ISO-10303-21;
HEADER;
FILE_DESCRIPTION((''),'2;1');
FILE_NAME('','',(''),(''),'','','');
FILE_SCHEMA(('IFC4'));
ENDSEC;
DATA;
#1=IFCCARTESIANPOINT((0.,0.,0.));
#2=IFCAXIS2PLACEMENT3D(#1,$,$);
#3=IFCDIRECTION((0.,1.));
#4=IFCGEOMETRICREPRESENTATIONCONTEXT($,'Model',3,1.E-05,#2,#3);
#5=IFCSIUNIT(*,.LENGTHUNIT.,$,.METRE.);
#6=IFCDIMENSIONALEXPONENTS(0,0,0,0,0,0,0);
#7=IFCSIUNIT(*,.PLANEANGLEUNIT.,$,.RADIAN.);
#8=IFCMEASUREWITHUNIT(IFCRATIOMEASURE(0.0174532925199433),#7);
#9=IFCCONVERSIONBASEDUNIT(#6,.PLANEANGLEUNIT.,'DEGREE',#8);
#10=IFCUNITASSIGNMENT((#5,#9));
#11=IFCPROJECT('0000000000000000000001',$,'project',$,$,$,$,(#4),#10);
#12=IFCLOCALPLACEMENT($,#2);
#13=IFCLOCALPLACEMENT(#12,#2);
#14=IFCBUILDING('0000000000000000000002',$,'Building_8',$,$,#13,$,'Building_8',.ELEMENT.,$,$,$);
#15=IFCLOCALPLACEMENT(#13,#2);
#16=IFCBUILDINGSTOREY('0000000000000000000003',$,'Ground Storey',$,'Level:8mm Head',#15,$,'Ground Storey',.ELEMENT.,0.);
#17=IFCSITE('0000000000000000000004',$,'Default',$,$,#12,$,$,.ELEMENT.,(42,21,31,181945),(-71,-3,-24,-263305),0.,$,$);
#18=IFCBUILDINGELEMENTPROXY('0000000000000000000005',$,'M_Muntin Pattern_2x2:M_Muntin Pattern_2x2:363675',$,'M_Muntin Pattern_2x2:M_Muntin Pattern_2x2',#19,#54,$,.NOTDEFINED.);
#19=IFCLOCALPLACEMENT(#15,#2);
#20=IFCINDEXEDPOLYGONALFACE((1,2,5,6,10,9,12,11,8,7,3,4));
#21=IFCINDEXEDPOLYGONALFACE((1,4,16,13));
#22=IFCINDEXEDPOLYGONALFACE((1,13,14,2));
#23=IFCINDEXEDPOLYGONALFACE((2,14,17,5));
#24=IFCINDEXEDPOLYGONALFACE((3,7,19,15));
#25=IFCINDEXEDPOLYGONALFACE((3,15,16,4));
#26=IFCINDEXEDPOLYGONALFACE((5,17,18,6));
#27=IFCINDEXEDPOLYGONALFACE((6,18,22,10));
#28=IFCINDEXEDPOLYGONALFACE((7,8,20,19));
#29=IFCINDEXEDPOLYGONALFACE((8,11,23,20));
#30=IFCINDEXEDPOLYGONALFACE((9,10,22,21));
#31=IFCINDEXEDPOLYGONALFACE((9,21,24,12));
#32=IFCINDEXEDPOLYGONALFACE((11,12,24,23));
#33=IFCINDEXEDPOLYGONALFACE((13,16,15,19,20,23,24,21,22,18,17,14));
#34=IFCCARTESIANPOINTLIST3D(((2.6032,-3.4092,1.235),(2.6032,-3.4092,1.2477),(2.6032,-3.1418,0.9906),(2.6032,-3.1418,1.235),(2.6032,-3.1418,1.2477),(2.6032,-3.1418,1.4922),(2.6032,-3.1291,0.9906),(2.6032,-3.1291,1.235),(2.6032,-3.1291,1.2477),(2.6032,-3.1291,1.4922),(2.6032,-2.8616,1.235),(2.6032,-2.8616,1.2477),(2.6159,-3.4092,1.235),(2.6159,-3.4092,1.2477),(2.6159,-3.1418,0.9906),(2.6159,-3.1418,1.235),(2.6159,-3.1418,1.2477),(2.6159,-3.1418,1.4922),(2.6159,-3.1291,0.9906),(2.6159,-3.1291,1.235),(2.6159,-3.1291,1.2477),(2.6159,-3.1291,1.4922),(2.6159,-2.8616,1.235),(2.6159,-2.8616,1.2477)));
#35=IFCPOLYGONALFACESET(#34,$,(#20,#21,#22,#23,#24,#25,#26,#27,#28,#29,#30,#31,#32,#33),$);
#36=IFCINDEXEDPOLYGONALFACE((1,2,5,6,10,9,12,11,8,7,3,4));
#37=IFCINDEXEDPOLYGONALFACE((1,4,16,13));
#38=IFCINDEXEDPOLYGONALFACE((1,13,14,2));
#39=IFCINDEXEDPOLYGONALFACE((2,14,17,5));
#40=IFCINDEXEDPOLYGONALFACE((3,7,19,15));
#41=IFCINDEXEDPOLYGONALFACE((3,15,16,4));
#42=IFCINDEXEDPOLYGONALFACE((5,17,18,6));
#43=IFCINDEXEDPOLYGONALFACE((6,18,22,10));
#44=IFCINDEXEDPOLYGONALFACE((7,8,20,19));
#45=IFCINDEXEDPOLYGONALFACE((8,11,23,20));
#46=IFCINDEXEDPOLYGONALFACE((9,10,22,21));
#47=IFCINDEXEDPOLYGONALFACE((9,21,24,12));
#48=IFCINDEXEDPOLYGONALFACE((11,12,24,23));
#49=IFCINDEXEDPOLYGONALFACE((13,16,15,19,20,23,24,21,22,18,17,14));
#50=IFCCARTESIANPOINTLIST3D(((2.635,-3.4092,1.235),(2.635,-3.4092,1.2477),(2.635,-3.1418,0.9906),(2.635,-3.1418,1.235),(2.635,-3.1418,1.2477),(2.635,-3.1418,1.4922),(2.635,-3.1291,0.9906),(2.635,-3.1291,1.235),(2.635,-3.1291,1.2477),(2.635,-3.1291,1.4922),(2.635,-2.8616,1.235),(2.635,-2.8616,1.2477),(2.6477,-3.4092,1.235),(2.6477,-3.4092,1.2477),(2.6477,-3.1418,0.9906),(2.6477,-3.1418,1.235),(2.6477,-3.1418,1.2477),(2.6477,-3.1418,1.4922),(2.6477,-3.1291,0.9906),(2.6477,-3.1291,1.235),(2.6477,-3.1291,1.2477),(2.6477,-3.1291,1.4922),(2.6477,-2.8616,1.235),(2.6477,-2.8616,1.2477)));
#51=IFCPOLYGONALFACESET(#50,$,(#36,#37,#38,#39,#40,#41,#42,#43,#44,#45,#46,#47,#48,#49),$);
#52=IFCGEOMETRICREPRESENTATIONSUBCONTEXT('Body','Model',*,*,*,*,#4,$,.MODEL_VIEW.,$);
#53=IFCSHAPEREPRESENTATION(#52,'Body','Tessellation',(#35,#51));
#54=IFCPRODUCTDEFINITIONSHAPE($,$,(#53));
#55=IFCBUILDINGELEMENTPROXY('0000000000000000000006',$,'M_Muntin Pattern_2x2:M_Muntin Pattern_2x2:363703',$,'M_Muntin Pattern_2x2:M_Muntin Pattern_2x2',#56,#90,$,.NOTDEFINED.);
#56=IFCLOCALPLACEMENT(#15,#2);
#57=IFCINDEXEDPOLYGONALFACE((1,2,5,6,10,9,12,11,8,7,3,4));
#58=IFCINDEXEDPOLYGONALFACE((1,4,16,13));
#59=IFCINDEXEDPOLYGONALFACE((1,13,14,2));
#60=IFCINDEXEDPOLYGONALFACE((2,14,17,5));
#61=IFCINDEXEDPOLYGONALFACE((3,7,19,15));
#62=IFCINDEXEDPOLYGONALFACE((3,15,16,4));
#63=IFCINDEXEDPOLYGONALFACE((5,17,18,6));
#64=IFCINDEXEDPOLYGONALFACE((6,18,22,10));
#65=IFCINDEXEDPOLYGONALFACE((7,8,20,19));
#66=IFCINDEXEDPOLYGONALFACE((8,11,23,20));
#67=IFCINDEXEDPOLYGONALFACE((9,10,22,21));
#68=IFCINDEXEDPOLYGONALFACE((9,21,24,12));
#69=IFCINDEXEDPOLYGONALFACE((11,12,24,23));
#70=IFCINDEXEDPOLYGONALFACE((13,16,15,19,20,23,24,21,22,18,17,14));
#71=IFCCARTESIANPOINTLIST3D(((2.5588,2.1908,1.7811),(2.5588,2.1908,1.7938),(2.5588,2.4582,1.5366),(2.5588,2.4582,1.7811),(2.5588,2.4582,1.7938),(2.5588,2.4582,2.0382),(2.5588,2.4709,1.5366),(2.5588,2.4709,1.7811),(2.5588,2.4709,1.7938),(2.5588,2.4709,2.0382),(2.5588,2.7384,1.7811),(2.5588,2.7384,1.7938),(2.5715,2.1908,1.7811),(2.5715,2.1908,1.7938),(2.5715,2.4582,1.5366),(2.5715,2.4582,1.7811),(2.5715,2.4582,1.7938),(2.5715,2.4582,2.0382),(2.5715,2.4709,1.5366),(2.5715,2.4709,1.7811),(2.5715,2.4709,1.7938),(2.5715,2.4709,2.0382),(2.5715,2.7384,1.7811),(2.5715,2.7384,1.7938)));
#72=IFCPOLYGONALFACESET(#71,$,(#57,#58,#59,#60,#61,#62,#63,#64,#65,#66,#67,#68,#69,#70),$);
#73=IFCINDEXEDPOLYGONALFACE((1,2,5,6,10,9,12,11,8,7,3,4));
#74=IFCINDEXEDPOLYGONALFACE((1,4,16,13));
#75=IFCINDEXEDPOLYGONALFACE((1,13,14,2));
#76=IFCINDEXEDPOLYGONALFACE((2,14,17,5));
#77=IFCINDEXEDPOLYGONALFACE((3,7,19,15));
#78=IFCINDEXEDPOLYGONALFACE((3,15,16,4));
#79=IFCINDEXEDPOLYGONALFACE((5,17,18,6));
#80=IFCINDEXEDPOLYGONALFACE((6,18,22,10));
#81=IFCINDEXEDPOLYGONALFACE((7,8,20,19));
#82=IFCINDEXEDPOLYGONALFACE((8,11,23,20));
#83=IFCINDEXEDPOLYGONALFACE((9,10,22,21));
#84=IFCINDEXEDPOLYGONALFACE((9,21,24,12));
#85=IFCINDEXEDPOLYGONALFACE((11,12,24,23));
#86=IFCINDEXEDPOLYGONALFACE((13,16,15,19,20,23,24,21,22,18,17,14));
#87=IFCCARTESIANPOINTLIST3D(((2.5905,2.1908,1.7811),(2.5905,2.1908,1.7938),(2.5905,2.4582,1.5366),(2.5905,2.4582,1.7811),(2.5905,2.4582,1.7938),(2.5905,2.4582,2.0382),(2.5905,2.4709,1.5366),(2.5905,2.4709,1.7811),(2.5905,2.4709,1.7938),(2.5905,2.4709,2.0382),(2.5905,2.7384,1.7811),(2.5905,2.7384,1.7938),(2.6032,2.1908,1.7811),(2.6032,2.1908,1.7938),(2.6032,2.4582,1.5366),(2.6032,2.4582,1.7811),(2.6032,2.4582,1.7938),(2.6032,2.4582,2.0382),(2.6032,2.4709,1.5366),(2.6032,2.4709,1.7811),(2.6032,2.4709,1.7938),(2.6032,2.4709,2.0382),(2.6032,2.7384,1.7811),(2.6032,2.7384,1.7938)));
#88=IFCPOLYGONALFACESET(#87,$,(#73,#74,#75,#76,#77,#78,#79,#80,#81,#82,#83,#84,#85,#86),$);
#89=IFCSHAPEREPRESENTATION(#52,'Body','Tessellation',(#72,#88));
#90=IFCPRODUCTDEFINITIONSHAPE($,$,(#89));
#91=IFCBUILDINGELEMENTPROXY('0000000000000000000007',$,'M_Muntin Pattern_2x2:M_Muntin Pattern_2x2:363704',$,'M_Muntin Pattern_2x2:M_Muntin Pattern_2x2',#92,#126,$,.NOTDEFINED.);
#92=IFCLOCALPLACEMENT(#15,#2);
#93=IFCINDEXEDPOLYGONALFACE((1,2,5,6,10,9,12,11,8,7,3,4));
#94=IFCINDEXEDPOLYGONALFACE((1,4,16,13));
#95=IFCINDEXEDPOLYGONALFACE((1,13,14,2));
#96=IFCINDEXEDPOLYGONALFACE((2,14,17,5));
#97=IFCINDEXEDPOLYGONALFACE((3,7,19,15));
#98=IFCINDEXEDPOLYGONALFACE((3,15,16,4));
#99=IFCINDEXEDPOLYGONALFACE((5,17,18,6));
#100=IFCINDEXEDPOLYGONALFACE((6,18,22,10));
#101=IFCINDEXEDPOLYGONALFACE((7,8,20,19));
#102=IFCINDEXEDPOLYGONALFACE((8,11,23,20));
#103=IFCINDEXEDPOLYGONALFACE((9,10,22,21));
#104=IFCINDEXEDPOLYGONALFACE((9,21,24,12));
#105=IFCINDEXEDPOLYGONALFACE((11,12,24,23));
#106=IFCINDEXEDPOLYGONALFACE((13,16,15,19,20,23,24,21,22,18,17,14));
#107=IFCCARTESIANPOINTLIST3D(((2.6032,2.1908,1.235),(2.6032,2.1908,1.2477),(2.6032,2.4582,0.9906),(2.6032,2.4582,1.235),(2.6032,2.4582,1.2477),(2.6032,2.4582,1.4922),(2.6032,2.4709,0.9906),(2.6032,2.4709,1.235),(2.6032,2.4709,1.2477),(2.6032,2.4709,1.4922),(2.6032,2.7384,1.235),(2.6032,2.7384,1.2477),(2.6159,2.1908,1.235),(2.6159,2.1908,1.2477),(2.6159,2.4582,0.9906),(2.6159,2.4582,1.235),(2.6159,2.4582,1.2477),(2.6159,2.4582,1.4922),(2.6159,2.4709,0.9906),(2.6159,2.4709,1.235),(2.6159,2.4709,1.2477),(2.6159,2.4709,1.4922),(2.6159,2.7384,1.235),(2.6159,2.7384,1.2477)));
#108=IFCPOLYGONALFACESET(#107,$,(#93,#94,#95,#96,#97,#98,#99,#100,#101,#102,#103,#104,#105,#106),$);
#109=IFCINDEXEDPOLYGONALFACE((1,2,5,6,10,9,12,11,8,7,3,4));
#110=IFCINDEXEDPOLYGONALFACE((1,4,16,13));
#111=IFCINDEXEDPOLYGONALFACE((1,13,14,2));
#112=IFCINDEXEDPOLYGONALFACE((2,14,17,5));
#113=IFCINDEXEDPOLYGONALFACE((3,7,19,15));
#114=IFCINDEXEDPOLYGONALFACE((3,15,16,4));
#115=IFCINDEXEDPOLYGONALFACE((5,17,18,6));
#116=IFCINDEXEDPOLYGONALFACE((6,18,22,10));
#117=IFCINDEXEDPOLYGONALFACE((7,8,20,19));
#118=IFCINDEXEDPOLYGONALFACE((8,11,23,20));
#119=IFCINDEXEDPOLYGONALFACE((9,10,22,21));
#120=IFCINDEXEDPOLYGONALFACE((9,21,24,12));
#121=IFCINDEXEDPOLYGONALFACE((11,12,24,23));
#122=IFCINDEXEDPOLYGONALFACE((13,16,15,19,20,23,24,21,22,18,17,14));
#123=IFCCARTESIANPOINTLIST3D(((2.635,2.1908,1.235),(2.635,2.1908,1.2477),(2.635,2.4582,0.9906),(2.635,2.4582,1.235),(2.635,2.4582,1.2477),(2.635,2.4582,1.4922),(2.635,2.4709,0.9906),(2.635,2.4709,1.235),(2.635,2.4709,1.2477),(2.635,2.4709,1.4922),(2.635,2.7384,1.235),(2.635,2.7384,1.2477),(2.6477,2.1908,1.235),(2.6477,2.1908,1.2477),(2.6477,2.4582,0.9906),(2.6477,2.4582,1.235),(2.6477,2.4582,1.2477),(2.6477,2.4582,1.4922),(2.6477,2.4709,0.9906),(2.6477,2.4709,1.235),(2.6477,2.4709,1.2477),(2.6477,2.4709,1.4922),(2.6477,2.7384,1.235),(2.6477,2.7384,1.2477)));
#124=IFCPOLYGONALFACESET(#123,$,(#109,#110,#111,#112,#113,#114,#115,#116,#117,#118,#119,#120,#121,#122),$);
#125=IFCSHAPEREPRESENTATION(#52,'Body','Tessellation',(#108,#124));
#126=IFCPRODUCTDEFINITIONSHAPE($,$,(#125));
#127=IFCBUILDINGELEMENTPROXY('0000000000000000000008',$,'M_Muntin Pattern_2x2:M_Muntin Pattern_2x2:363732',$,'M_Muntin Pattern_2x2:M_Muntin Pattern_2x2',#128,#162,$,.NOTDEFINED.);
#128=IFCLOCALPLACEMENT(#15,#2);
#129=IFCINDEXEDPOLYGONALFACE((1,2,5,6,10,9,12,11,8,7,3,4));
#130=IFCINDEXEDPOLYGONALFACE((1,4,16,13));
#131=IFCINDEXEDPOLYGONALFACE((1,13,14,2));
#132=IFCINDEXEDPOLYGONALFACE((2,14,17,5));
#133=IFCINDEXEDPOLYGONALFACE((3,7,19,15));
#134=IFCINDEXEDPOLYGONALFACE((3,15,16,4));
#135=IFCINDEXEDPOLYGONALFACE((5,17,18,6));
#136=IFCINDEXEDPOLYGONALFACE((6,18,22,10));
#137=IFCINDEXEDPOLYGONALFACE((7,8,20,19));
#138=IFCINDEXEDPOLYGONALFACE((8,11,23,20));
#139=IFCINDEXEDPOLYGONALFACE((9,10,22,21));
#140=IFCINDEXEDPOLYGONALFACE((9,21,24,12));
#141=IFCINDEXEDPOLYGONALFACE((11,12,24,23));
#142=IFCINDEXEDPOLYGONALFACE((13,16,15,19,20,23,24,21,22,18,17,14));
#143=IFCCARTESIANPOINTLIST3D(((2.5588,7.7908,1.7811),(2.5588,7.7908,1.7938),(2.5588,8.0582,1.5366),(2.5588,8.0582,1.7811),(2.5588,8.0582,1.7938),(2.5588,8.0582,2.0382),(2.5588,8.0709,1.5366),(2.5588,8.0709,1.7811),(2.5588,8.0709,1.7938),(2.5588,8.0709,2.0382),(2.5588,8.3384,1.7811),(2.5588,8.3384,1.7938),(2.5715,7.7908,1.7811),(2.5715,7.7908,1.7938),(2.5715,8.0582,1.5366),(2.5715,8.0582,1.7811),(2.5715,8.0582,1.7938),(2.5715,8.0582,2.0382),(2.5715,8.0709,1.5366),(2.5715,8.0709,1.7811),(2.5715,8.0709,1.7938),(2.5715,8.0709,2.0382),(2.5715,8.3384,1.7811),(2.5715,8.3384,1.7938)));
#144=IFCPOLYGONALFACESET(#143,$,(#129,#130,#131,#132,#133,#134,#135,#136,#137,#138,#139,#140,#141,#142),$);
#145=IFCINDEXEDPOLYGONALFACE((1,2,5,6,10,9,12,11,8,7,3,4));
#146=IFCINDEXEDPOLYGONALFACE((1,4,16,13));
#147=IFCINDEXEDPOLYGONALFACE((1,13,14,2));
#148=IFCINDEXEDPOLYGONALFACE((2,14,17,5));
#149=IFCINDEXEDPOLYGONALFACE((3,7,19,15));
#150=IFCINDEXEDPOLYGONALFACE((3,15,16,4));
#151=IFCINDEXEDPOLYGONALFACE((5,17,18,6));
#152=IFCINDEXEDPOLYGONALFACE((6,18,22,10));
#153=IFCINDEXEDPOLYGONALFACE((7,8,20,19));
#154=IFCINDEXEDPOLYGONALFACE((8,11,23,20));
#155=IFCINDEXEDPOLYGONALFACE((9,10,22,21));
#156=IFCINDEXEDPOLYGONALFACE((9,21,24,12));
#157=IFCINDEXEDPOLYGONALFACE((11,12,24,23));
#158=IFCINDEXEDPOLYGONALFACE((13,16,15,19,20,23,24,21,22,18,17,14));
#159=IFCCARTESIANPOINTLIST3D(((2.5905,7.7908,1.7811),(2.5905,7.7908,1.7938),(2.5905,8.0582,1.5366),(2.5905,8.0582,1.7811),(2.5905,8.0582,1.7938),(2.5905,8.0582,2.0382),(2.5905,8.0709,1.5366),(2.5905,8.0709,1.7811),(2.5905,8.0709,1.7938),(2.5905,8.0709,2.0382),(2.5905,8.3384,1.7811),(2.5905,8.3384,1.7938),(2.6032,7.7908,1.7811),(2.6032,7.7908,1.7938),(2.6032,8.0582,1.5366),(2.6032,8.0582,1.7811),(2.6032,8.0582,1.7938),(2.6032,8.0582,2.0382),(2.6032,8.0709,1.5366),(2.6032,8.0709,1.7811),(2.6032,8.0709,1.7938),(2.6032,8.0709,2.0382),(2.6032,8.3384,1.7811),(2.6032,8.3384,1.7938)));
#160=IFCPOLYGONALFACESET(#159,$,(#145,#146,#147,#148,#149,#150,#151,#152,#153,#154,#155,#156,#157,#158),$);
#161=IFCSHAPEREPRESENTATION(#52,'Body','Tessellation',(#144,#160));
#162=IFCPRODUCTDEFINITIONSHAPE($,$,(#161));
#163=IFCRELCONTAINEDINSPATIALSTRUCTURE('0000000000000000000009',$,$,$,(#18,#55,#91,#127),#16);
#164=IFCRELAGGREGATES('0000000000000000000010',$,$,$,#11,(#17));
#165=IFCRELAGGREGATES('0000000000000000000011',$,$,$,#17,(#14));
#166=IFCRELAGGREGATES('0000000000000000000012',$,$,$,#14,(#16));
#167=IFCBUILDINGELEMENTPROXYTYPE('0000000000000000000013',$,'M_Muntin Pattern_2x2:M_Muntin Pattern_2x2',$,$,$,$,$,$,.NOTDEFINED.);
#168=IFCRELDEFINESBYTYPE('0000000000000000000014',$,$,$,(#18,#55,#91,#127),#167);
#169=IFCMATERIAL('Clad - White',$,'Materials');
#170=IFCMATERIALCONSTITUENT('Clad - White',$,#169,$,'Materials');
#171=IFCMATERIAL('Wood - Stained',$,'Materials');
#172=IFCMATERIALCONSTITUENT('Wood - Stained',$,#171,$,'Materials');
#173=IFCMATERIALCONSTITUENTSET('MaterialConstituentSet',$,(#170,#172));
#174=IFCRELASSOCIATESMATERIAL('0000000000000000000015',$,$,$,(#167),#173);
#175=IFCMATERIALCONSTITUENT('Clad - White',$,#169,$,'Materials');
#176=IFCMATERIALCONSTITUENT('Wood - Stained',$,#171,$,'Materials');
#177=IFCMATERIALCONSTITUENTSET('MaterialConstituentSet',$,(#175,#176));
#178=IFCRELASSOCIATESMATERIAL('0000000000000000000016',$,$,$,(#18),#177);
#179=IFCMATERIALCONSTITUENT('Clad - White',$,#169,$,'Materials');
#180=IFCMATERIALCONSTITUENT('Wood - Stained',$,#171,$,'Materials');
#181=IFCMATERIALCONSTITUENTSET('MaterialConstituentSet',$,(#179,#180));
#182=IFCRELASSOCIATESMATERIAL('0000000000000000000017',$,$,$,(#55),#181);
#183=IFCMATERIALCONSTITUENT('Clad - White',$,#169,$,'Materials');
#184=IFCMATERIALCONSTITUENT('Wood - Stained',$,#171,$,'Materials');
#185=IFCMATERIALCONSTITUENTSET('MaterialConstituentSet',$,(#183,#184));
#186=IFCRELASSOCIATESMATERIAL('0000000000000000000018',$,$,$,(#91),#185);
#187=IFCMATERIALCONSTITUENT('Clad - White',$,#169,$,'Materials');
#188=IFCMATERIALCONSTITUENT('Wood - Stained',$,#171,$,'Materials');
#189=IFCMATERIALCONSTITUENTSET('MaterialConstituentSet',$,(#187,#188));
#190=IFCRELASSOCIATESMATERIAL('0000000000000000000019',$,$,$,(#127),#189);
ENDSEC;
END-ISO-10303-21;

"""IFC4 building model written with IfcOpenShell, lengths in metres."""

from ifc_helpers import new_model, entity, si_unit, converted_unit, direction, frame, origin, place, context, subcontext, project, spatial, indexed_curve, outline, extrude, source, transform, mapped, material, constituent, constituent_set, type_object, type_shapes, element, save


model = new_model("IFC4")

# Units and contexts
model_context = context("Model", 3, precision=1e-05, world=origin(), true_north=direction((0.0, 1.0)))
body_context = subcontext(model_context, "Body", "Model", "MODEL_VIEW")
ifc_project = project(units=[si_unit("LENGTHUNIT", "METRE"), converted_unit("PLANEANGLEUNIT", "DEGREE", entity("IfcRatioMeasure", 0.0174532925199433), si_unit("PLANEANGLEUNIT", "RADIAN"), dimensions=[0, 0, 0, 0, 0, 0, 0])], contexts=[model_context])

# Site, building, storey
site_placement = place(None, origin())
site = spatial("IfcSite", under=ifc_project, at=site_placement, Name="Default", CompositionType="ELEMENT", RefLatitude=(42, 21, 31, 181945), RefLongitude=(-71, -3, -24, -263305), RefElevation=0.0)
building_placement = place(site_placement, origin())
building = spatial("IfcBuilding", under=site, at=building_placement, Name="Building_8", LongName="Building_8", CompositionType="ELEMENT")
storey_placement = place(building_placement, origin())
storey = spatial("IfcBuildingStorey", under=building, at=storey_placement, Name="Ground Storey", ObjectType="Level:8mm Head", LongName="Ground Storey", CompositionType="ELEMENT", Elevation=0.0)

# Building element proxies
ifc_material_1 = material(Name="Clad - White", Category="Materials")
ifc_material_2 = material(Name="Wood - Stained", Category="Materials")
ifc_constituent_1 = constituent(ifc_material_1, Name="Clad - White", Category="Materials")
ifc_constituent_2 = constituent(ifc_material_2, Name="Wood - Stained", Category="Materials")
ifc_constituent_set_1 = constituent_set(constituents=[ifc_constituent_1, ifc_constituent_2], Name="MaterialConstituentSet")
building_element_proxy_type_1 = type_object("IfcBuildingElementProxyType", Name="M_Muntin Pattern_2x2:M_Muntin Pattern_2x2", PredefinedType="NOTDEFINED", material=ifc_constituent_set_1)
shared_shape_1 = source(origin(), body_context, "Body", "SweptSolid", [
    extrude(outline(indexed_curve([(0.0064, -0.0064), (0.2508, -0.0064), (0.2508, 0.0063), (0.0064, 0.0063), (0.0064, 0.2738), (-0.0063, 0.2738), (-0.0063, 0.0063), (-0.2508, 0.0063), (-0.2508, -0.0064), (-0.0063, -0.0064), (-0.0063, -0.2738), (0.0064, -0.2738), (0.0064, -0.0064)], self_intersect=False)), frame((0.0, 0.0095, 0.2508), z_axis=(0.0, 1.0, 0.0), x_axis=(0.0, 0.0, 1.0)), (0.0, 0.0, 1.0), 0.0127),
    extrude(outline(indexed_curve([(0.0064, -0.0064), (0.2508, -0.0064), (0.2508, 0.0063), (0.0064, 0.0063), (0.0064, 0.2738), (-0.0063, 0.2738), (-0.0063, 0.0063), (-0.2508, 0.0063), (-0.2508, -0.0064), (-0.0063, -0.0064), (-0.0063, -0.2738), (0.0064, -0.2738), (0.0064, -0.0064)], self_intersect=False)), frame((0.0, -0.0222, 0.2508), z_axis=(0.0, 1.0, 0.0), x_axis=(0.0, 0.0, 1.0)), (0.0, 0.0, 1.0), 0.0127),
])
type_shapes(building_element_proxy_type_1, [shared_shape_1])
ifc_constituent_3 = constituent(ifc_material_1, Name="Clad - White", Category="Materials")
ifc_constituent_4 = constituent(ifc_material_2, Name="Wood - Stained", Category="Materials")
ifc_constituent_set_2 = constituent_set(constituents=[ifc_constituent_3, ifc_constituent_4], Name="MaterialConstituentSet")
proxy_1_placement = place(storey_placement, frame((2.6255, -3.1354, 0.9906), z_axis=(0.0, 0.0, 1.0), x_axis=(0.0, 1.0, 0.0)))
element("IfcBuildingElementProxy", 1, at=proxy_1_placement, inside=storey, type_object=building_element_proxy_type_1, material=ifc_constituent_set_2, Name="M_Muntin Pattern_2x2:M_Muntin Pattern_2x2:363675", ObjectType="M_Muntin Pattern_2x2:M_Muntin Pattern_2x2", PredefinedType="NOTDEFINED", context=body_context, shape_type="MappedRepresentation", body=[
    mapped(shared_shape_1, transform((0.0, 0.0, 0.0), scale=1.0)),
])
ifc_constituent_5 = constituent(ifc_material_1, Name="Clad - White", Category="Materials")
ifc_constituent_6 = constituent(ifc_material_2, Name="Wood - Stained", Category="Materials")
ifc_constituent_set_3 = constituent_set(constituents=[ifc_constituent_5, ifc_constituent_6], Name="MaterialConstituentSet")
proxy_2_placement = place(storey_placement, frame((2.581, 2.4646, 1.5366), z_axis=(0.0, 0.0, 1.0), x_axis=(0.0, 1.0, 0.0)))
element("IfcBuildingElementProxy", 2, at=proxy_2_placement, inside=storey, type_object=building_element_proxy_type_1, material=ifc_constituent_set_3, Name="M_Muntin Pattern_2x2:M_Muntin Pattern_2x2:363703", ObjectType="M_Muntin Pattern_2x2:M_Muntin Pattern_2x2", PredefinedType="NOTDEFINED", context=body_context, shape_type="MappedRepresentation", body=[
    mapped(shared_shape_1, transform((0.0, 0.0, 0.0), scale=1.0)),
])
ifc_constituent_7 = constituent(ifc_material_1, Name="Clad - White", Category="Materials")
ifc_constituent_8 = constituent(ifc_material_2, Name="Wood - Stained", Category="Materials")
ifc_constituent_set_4 = constituent_set(constituents=[ifc_constituent_7, ifc_constituent_8], Name="MaterialConstituentSet")
proxy_3_placement = place(storey_placement, frame((2.6255, 2.4646, 0.9906), z_axis=(0.0, 0.0, 1.0), x_axis=(0.0, 1.0, 0.0)))
element("IfcBuildingElementProxy", 3, at=proxy_3_placement, inside=storey, type_object=building_element_proxy_type_1, material=ifc_constituent_set_4, Name="M_Muntin Pattern_2x2:M_Muntin Pattern_2x2:363704", ObjectType="M_Muntin Pattern_2x2:M_Muntin Pattern_2x2", PredefinedType="NOTDEFINED", context=body_context, shape_type="MappedRepresentation", body=[
    mapped(shared_shape_1, transform((0.0, 0.0, 0.0), scale=1.0)),
])
ifc_constituent_9 = constituent(ifc_material_1, Name="Clad - White", Category="Materials")
ifc_constituent_10 = constituent(ifc_material_2, Name="Wood - Stained", Category="Materials")
ifc_constituent_set_5 = constituent_set(constituents=[ifc_constituent_9, ifc_constituent_10], Name="MaterialConstituentSet")
proxy_4_placement = place(storey_placement, frame((2.581, 8.0646, 1.5366), z_axis=(0.0, 0.0, 1.0), x_axis=(0.0, 1.0, 0.0)))
element("IfcBuildingElementProxy", 4, at=proxy_4_placement, inside=storey, type_object=building_element_proxy_type_1, material=ifc_constituent_set_5, Name="M_Muntin Pattern_2x2:M_Muntin Pattern_2x2:363732", ObjectType="M_Muntin Pattern_2x2:M_Muntin Pattern_2x2", PredefinedType="NOTDEFINED", context=body_context, shape_type="MappedRepresentation", body=[
    mapped(shared_shape_1, transform((0.0, 0.0, 0.0), scale=1.0)),
])

save(model, "model.ifc")
